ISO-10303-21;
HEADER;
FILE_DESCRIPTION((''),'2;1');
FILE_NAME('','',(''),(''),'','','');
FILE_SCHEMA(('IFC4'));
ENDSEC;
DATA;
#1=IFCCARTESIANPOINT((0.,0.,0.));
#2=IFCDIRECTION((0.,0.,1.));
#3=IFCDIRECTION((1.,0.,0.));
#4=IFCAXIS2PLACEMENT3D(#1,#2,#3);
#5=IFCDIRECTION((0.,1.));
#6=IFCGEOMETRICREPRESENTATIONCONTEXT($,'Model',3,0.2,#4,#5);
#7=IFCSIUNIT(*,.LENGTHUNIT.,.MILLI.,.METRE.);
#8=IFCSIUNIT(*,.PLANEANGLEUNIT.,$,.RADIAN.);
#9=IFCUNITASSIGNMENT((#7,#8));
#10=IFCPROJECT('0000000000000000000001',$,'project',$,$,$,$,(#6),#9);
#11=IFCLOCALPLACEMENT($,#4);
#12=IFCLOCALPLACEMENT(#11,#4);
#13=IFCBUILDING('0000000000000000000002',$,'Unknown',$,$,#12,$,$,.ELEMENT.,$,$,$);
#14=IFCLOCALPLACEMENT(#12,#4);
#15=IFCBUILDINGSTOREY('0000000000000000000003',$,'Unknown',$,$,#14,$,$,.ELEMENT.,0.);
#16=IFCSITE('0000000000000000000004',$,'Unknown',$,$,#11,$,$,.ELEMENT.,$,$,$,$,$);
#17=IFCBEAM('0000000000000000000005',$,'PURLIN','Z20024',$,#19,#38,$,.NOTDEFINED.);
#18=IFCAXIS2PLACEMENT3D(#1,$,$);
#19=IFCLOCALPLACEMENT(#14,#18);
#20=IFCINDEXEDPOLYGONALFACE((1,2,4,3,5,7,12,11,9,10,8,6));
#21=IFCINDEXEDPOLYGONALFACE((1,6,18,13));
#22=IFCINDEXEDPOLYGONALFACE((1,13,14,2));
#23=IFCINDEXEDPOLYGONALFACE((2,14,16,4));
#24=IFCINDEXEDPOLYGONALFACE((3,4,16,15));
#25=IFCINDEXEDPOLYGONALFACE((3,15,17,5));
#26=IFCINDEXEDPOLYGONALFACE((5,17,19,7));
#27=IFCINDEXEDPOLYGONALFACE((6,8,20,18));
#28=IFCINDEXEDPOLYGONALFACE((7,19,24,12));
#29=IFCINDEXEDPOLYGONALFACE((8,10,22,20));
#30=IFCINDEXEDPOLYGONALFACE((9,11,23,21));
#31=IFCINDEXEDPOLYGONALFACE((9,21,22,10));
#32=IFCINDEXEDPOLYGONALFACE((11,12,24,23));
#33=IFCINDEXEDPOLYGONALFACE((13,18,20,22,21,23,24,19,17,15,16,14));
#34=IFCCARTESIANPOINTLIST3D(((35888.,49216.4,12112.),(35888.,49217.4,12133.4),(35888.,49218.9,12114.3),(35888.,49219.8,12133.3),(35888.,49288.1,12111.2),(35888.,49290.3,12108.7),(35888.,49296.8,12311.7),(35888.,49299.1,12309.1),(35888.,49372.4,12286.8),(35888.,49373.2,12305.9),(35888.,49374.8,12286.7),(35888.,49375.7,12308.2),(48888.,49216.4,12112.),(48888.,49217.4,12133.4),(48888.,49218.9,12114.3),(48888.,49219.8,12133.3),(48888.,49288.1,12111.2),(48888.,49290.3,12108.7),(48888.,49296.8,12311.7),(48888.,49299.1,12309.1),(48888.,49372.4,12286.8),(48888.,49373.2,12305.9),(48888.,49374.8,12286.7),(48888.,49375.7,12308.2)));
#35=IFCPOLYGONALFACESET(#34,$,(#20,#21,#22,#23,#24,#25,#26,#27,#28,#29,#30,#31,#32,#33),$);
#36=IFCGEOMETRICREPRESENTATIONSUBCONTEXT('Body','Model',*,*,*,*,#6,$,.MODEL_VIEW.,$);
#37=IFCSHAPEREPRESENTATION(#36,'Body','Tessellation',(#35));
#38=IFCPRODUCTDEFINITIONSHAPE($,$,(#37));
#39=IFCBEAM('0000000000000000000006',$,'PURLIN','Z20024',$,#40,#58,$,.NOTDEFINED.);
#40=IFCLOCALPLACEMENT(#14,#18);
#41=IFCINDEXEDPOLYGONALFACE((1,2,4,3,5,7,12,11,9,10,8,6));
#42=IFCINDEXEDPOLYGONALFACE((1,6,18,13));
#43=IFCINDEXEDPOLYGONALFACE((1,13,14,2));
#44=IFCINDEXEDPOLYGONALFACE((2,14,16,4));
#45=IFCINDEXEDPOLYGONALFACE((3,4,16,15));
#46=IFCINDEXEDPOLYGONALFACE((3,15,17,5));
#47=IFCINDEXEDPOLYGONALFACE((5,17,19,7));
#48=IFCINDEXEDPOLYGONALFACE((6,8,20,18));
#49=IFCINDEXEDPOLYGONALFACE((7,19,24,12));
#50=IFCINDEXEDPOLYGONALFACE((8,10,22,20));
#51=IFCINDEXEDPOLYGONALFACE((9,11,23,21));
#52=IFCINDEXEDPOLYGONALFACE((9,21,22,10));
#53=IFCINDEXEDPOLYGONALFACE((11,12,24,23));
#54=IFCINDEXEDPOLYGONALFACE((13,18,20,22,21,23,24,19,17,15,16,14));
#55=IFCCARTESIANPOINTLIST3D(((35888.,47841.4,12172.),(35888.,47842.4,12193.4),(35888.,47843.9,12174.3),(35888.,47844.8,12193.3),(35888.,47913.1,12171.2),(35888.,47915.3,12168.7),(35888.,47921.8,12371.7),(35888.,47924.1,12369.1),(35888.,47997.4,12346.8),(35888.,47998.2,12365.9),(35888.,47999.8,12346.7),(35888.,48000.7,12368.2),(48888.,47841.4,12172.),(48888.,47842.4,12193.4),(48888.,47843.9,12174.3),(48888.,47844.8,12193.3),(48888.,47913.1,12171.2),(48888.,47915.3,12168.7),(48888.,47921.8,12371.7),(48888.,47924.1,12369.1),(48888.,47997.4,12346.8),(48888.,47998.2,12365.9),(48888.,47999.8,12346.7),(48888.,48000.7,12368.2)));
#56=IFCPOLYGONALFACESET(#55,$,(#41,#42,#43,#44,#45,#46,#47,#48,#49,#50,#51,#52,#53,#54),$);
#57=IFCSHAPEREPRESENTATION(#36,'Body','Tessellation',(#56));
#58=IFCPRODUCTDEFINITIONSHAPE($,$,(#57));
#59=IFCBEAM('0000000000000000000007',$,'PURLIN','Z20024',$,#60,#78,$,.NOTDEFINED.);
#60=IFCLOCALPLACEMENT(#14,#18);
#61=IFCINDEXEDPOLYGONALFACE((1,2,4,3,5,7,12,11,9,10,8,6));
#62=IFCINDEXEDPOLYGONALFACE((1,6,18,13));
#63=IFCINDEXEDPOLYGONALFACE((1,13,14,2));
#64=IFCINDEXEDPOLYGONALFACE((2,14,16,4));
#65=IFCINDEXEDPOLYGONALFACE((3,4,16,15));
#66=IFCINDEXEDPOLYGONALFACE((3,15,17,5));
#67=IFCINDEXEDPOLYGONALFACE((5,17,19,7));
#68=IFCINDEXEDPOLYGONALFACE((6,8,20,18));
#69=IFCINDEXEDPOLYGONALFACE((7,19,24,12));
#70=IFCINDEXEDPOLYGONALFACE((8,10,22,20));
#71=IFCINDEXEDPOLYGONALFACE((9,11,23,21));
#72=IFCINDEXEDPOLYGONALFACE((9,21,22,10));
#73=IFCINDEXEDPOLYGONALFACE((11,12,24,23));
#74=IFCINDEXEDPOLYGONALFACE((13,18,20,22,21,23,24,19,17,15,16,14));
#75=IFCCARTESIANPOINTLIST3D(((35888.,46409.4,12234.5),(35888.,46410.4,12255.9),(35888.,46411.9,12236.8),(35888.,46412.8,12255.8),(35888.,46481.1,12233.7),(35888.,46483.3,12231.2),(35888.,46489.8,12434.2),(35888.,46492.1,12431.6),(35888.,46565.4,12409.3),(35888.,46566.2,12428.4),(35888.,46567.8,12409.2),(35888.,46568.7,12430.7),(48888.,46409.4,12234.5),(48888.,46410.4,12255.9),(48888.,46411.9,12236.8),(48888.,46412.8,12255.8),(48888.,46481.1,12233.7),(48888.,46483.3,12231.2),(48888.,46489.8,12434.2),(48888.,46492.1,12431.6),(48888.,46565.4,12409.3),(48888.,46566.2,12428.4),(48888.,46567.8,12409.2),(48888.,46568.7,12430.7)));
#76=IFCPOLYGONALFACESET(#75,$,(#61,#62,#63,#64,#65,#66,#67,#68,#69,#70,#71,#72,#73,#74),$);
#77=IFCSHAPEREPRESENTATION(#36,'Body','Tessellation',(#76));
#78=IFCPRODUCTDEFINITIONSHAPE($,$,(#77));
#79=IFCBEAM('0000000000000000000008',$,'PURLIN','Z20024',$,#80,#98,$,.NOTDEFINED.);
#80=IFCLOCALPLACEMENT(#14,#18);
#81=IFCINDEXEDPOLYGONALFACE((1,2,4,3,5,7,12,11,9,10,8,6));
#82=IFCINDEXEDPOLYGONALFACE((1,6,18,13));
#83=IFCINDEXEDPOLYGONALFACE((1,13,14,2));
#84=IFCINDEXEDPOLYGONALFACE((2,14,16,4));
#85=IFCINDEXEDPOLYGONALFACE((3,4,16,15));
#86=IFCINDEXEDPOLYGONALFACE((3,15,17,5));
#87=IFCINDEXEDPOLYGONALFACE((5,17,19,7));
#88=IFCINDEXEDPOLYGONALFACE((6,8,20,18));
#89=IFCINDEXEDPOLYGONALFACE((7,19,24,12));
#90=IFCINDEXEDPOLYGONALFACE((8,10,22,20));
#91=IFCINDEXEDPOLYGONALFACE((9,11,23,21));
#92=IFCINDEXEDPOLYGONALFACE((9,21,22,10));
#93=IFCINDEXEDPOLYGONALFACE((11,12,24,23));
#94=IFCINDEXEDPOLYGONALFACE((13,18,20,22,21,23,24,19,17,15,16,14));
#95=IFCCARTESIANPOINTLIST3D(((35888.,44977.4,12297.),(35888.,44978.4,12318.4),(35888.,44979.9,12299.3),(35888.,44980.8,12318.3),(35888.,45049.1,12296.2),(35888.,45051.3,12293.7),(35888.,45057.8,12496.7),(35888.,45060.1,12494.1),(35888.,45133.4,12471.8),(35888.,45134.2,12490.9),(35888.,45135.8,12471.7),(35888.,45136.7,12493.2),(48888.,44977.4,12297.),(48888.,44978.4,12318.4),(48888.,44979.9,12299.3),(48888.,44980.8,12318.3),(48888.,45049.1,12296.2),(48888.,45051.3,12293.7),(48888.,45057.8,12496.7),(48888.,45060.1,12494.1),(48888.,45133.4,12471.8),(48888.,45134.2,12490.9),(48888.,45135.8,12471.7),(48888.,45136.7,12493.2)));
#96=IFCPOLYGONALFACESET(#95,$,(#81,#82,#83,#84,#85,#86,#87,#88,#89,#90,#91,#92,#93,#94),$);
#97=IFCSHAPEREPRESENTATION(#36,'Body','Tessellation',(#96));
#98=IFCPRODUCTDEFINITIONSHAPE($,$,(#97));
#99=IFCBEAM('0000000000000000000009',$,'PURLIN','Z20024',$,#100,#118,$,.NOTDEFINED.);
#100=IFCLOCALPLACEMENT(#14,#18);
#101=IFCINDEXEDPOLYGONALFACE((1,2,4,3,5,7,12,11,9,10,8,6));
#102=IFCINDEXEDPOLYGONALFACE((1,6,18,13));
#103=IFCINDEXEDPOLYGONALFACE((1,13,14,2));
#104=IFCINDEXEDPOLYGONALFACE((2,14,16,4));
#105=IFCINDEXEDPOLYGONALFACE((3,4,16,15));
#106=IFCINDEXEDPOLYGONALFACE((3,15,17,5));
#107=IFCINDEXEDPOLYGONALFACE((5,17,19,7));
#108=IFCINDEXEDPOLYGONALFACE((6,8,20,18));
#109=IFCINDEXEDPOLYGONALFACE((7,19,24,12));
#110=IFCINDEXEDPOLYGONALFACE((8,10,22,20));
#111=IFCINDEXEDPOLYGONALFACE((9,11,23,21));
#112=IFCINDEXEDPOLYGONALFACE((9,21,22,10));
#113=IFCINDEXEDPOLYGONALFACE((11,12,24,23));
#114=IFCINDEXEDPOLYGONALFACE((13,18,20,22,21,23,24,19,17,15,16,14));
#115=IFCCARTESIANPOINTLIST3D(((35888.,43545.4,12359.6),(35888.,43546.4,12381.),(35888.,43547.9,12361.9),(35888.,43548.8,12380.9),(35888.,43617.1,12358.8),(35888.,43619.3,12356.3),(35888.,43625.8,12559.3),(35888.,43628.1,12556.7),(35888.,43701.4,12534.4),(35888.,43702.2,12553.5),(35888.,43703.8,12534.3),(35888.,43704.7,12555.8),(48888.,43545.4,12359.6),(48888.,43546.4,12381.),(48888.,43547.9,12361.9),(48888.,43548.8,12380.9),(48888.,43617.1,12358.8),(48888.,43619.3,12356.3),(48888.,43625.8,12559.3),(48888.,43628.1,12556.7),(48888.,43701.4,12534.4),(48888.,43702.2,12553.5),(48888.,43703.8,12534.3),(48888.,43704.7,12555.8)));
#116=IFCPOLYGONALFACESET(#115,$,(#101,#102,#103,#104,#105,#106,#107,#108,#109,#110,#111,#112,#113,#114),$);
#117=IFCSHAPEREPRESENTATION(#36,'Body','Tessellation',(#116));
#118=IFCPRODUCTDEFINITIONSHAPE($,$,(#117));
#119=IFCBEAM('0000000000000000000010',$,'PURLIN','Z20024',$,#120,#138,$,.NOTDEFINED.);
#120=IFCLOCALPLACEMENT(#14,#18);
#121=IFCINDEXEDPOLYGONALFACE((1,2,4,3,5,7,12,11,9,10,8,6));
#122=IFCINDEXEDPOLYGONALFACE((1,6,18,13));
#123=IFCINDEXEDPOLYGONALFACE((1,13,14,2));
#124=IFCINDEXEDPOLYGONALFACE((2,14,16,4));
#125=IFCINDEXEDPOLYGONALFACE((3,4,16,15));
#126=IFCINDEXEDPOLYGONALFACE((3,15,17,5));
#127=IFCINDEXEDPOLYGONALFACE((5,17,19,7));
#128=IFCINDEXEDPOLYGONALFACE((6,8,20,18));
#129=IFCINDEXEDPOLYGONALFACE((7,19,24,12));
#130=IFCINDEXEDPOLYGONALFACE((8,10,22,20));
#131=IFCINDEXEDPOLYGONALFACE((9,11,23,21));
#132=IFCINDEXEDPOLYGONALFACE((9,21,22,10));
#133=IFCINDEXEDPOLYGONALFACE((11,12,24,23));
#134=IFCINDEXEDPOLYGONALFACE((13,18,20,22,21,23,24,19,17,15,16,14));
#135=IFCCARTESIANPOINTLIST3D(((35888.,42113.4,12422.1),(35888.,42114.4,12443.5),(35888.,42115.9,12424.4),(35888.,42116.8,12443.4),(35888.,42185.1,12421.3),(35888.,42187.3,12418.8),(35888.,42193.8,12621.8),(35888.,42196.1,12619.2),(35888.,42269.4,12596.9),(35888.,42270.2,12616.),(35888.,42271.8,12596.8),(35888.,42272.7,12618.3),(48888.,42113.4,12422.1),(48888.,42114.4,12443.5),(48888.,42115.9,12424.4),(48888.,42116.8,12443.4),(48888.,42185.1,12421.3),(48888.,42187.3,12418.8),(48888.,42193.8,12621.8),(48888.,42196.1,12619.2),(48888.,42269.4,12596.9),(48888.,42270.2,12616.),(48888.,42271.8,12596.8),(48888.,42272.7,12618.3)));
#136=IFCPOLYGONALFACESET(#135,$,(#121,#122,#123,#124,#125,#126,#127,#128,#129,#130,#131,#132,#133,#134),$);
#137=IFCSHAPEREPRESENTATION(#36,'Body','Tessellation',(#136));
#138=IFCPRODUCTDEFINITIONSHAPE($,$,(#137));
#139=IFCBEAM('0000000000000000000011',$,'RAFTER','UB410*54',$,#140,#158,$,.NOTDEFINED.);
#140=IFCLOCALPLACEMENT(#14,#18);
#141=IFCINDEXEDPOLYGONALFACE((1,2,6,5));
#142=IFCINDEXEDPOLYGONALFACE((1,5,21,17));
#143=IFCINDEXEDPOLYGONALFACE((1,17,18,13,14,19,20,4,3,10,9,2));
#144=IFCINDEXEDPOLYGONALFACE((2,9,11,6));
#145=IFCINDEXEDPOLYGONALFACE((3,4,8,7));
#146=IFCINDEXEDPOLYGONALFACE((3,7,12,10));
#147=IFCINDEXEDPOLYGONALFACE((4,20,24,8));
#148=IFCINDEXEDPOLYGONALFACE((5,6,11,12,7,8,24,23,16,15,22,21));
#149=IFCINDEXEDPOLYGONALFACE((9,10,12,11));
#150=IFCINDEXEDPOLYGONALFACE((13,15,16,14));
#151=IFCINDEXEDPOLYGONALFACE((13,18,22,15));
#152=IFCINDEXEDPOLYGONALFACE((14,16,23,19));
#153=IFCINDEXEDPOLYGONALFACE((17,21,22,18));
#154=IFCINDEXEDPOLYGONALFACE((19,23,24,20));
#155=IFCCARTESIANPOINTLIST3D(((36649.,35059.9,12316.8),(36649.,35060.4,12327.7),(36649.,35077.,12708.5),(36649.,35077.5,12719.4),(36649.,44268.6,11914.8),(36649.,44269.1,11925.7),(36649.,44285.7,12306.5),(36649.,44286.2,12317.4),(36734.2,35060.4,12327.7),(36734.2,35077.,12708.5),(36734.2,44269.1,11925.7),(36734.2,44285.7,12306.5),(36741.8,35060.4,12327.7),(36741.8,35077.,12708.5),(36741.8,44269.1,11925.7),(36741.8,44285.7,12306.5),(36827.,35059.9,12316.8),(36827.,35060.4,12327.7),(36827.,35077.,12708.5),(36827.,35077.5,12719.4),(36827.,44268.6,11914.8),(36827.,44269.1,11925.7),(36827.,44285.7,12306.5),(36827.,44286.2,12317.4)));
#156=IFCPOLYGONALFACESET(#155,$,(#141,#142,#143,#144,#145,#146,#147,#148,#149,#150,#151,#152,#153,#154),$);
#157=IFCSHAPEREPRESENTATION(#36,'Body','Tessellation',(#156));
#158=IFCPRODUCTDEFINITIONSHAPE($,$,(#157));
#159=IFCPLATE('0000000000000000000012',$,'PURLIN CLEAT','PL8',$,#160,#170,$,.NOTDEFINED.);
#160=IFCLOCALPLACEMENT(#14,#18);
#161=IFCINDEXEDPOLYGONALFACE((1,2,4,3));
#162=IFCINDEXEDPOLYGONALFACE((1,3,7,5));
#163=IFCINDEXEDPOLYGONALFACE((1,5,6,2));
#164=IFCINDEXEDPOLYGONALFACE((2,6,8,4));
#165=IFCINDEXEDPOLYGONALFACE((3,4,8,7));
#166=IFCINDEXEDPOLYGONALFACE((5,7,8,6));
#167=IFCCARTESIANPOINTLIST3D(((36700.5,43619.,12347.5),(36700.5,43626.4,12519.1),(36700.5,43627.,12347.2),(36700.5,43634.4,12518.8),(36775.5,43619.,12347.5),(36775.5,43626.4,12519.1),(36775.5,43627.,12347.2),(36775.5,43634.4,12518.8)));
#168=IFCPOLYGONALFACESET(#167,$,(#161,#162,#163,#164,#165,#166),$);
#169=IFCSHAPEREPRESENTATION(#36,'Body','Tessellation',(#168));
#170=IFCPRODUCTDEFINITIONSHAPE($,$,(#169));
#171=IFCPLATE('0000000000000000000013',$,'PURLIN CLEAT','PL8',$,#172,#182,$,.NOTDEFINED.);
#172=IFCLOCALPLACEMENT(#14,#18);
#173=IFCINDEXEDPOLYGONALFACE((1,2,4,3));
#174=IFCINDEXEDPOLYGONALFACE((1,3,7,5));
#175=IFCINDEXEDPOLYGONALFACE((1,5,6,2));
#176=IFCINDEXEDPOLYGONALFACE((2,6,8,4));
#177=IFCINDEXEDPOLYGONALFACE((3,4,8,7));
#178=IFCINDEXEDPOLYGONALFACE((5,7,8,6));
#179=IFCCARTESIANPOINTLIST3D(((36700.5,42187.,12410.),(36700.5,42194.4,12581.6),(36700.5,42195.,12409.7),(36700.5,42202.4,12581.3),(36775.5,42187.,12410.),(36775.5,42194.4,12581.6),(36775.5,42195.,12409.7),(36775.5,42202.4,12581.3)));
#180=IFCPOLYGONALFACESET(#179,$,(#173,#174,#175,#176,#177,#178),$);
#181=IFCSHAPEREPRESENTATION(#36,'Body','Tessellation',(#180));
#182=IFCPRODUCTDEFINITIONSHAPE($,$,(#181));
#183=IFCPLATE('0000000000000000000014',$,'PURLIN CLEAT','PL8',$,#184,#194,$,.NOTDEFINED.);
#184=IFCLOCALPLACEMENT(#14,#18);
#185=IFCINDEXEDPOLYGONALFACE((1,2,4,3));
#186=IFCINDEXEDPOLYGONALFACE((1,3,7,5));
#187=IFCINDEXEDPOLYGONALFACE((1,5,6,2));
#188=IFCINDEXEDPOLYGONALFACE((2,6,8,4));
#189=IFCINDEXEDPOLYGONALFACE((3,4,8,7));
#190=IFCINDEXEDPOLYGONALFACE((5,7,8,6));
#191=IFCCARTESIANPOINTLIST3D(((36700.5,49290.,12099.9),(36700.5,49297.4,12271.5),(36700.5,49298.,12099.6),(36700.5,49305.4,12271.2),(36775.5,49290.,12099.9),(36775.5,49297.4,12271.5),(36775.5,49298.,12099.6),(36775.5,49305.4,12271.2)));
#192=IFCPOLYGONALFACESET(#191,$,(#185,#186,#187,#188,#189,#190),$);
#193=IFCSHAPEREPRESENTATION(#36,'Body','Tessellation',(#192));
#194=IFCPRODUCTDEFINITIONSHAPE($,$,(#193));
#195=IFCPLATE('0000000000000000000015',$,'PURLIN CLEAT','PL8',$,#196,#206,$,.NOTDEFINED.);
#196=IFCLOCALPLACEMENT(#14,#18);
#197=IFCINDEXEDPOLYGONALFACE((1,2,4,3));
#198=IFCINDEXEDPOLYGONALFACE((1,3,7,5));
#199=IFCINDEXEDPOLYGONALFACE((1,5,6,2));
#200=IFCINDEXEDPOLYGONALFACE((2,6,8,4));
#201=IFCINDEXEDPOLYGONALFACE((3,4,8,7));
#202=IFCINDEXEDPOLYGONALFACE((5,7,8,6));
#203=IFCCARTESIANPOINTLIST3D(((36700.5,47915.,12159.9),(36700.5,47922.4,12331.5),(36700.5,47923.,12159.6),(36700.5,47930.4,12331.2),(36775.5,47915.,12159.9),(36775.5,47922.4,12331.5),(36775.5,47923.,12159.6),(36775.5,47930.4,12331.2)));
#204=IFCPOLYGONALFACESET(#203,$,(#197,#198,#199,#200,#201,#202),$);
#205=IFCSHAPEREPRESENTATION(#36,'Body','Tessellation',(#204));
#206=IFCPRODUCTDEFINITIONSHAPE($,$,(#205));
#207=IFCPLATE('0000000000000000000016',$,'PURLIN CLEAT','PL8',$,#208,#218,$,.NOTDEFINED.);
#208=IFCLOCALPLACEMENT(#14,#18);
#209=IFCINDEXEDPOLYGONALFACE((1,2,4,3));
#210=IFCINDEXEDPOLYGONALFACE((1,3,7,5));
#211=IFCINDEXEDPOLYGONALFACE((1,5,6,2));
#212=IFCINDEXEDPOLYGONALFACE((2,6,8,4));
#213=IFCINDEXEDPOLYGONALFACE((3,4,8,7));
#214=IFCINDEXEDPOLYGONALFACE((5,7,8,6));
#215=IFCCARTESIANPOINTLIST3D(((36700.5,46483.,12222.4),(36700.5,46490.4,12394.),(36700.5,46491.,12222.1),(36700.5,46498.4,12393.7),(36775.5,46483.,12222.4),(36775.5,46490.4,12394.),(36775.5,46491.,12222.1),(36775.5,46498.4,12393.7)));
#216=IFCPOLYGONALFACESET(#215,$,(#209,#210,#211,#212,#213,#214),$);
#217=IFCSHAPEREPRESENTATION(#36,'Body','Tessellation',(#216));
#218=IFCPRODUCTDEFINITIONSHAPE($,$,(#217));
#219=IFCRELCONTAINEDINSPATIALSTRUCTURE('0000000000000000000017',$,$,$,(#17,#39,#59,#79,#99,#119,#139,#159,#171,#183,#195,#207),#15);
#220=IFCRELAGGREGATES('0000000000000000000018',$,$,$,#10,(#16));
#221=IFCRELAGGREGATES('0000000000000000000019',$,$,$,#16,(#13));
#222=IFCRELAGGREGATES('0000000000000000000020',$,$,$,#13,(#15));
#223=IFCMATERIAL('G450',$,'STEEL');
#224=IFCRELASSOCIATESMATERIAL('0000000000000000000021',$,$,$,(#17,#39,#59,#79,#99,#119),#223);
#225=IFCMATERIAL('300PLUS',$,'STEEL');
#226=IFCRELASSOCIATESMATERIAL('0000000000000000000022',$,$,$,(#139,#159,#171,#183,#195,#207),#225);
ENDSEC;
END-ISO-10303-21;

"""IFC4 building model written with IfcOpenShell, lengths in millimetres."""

from ifc_helpers import new_model, si_unit, direction, frame, origin_with_axes, place, context, subcontext, project, spatial, line, indexed_curve, outline, extrude, material, element, save


model = new_model("IFC4")

# Units and contexts
model_context = context("Model", 3, precision=0.2, world=origin_with_axes(), true_north=direction((0.0, 1.0)))
body_context = subcontext(model_context, "Body", "Model", "MODEL_VIEW")
ifc_project = project(units=[si_unit("LENGTHUNIT", "METRE", prefix="MILLI"), si_unit("PLANEANGLEUNIT", "RADIAN")], contexts=[model_context])

# Site, building, storey
site_placement = place(None, origin_with_axes())
site = spatial("IfcSite", under=ifc_project, at=site_placement, Name="Unknown", CompositionType="ELEMENT")
building_placement = place(site_placement, origin_with_axes())
building = spatial("IfcBuilding", under=site, at=building_placement, Name="Unknown", CompositionType="ELEMENT")
storey_placement = place(building_placement, origin_with_axes())
storey = spatial("IfcBuildingStorey", under=building, at=storey_placement, Name="Unknown", CompositionType="ELEMENT", Elevation=0.0)

# Shared definitions
ifc_material_1 = material(Name="300PLUS", Category="STEEL")

# Beams
ifc_material_2 = material(Name="G450", Category="STEEL")
for number, where, z_axis, x_axis, name in (
    (1, (35888.0, 49293.6, 12210.2), (0.0, -0.999048, 0.043619), (1.0, 0.0, 0.0), "PURLIN"),
    (2, (35888.0, 47918.6, 12270.2), (0.0, -0.999048, 0.043619), (1.0, 0.0, 0.0), "PURLIN"),
    (3, (35888.0, 46486.6, 12332.7), (0.0, -0.999048, 0.043619), (1.0, 0.0, 0.0), "PURLIN"),
    (4, (35888.0, 45054.6, 12395.2), (0.0, -0.999048, 0.043619), (1.0, 0.0, 0.0), "PURLIN"),
    (5, (35888.0, 43622.6, 12457.8), (0.0, -0.999048, 0.043619), (1.0, 0.0, 0.0), "PURLIN"),
    (6, (35888.0, 42190.6, 12520.3), (0.0, -0.999048, 0.043619), (1.0, 0.0, 0.0), "PURLIN"),
):
    element("IfcBeam", number, at=place(storey_placement, frame(where, z_axis=z_axis, x_axis=x_axis)), inside=storey, material=ifc_material_2, Name=name, Description="Z20024", PredefinedType="NOTDEFINED", context=body_context, shape_type="SolidModel", body=[
        extrude(outline(indexed_curve([(72.8, -101.5), (72.8, -80.0), (70.4, -80.0), (70.4, -99.1), (1.2, -99.1), (1.2, 101.5), (-77.8, 101.5), (-77.8, 80.0), (-75.4, 80.0), (-75.4, 99.1), (-1.2, 99.1), (-1.2, -101.5)], segments=[line(1, 2, 3, 4, 5, 6, 7, 8, 9, 10, 11, 12, 1)])), frame((0.0, 0.0, 0.0), z_axis=(-1.0, 0.0, 0.0), x_axis=(0.0, 0.0, 1.0)), (0.0, 0.0, -1.0), 13000.0),
    ])
beam_placement = place(storey_placement, frame((36738.0, 44277.4, 12116.1), z_axis=(-1.0, 0.0, 0.0), x_axis=(0.0, -0.999049, 0.043613)))
element("IfcBeam", 7, at=beam_placement, inside=storey, material=ifc_material_1, Name="RAFTER", Description="UB410*54", PredefinedType="NOTDEFINED", context=body_context, shape_type="SolidModel", body=[
    extrude(outline(indexed_curve([(-89.0, -201.5), (89.0, -201.5), (89.0, -190.6), (3.8, -190.6), (3.8, 190.6), (89.0, 190.6), (89.0, 201.5), (-89.0, 201.5), (-89.0, 190.6), (-3.8, 190.6), (-3.8, -190.6), (-89.0, -190.6)], segments=[line(1, 2, 3, 4, 5, 6, 7, 8, 9, 10, 11, 12, 1)])), frame((0.0, 0.0, 0.0), z_axis=(-1.0, 0.0, 0.0), x_axis=(0.0, 0.0, 1.0)), (0.0, 0.0, -1.0), 9217.5),
])

# Plates
for number, where, z_axis, x_axis, name in (
    (8, (36700.5, 43623.0, 12347.4), (0.0, -0.999071, 0.043084), (1.0, 0.0, 0.0), "PURLIN CLEAT"),
    (9, (36700.5, 42191.0, 12409.9), (0.0, -0.999071, 0.043084), (1.0, 0.0, 0.0), "PURLIN CLEAT"),
    (10, (36700.5, 49294.0, 12099.8), (0.0, -0.999071, 0.043084), (1.0, 0.0, 0.0), "PURLIN CLEAT"),
    (11, (36700.5, 47919.0, 12159.8), (0.0, -0.999071, 0.043084), (1.0, 0.0, 0.0), "PURLIN CLEAT"),
    (12, (36700.5, 46487.0, 12222.3), (0.0, -0.999071, 0.043084), (1.0, 0.0, 0.0), "PURLIN CLEAT"),
):
    element("IfcPlate", number, at=place(storey_placement, frame(where, z_axis=z_axis, x_axis=x_axis)), inside=storey, material=ifc_material_1, Name=name, Description="PL8", PredefinedType="NOTDEFINED", context=body_context, shape_type="SolidModel", body=[
        extrude(outline(indexed_curve([(0.0, 0.0), (75.0, 0.0), (75.0, 171.8), (0.0, 171.8)], segments=[line(1, 2, 3, 4, 1)])), frame((0.0, 0.0, 4.0), z_axis=(0.0, 0.0, 1.0), x_axis=(1.0, 0.0, 0.0)), (0.0, 0.0, -1.0), 8.0),
    ])

save(model, "model.ifc")
